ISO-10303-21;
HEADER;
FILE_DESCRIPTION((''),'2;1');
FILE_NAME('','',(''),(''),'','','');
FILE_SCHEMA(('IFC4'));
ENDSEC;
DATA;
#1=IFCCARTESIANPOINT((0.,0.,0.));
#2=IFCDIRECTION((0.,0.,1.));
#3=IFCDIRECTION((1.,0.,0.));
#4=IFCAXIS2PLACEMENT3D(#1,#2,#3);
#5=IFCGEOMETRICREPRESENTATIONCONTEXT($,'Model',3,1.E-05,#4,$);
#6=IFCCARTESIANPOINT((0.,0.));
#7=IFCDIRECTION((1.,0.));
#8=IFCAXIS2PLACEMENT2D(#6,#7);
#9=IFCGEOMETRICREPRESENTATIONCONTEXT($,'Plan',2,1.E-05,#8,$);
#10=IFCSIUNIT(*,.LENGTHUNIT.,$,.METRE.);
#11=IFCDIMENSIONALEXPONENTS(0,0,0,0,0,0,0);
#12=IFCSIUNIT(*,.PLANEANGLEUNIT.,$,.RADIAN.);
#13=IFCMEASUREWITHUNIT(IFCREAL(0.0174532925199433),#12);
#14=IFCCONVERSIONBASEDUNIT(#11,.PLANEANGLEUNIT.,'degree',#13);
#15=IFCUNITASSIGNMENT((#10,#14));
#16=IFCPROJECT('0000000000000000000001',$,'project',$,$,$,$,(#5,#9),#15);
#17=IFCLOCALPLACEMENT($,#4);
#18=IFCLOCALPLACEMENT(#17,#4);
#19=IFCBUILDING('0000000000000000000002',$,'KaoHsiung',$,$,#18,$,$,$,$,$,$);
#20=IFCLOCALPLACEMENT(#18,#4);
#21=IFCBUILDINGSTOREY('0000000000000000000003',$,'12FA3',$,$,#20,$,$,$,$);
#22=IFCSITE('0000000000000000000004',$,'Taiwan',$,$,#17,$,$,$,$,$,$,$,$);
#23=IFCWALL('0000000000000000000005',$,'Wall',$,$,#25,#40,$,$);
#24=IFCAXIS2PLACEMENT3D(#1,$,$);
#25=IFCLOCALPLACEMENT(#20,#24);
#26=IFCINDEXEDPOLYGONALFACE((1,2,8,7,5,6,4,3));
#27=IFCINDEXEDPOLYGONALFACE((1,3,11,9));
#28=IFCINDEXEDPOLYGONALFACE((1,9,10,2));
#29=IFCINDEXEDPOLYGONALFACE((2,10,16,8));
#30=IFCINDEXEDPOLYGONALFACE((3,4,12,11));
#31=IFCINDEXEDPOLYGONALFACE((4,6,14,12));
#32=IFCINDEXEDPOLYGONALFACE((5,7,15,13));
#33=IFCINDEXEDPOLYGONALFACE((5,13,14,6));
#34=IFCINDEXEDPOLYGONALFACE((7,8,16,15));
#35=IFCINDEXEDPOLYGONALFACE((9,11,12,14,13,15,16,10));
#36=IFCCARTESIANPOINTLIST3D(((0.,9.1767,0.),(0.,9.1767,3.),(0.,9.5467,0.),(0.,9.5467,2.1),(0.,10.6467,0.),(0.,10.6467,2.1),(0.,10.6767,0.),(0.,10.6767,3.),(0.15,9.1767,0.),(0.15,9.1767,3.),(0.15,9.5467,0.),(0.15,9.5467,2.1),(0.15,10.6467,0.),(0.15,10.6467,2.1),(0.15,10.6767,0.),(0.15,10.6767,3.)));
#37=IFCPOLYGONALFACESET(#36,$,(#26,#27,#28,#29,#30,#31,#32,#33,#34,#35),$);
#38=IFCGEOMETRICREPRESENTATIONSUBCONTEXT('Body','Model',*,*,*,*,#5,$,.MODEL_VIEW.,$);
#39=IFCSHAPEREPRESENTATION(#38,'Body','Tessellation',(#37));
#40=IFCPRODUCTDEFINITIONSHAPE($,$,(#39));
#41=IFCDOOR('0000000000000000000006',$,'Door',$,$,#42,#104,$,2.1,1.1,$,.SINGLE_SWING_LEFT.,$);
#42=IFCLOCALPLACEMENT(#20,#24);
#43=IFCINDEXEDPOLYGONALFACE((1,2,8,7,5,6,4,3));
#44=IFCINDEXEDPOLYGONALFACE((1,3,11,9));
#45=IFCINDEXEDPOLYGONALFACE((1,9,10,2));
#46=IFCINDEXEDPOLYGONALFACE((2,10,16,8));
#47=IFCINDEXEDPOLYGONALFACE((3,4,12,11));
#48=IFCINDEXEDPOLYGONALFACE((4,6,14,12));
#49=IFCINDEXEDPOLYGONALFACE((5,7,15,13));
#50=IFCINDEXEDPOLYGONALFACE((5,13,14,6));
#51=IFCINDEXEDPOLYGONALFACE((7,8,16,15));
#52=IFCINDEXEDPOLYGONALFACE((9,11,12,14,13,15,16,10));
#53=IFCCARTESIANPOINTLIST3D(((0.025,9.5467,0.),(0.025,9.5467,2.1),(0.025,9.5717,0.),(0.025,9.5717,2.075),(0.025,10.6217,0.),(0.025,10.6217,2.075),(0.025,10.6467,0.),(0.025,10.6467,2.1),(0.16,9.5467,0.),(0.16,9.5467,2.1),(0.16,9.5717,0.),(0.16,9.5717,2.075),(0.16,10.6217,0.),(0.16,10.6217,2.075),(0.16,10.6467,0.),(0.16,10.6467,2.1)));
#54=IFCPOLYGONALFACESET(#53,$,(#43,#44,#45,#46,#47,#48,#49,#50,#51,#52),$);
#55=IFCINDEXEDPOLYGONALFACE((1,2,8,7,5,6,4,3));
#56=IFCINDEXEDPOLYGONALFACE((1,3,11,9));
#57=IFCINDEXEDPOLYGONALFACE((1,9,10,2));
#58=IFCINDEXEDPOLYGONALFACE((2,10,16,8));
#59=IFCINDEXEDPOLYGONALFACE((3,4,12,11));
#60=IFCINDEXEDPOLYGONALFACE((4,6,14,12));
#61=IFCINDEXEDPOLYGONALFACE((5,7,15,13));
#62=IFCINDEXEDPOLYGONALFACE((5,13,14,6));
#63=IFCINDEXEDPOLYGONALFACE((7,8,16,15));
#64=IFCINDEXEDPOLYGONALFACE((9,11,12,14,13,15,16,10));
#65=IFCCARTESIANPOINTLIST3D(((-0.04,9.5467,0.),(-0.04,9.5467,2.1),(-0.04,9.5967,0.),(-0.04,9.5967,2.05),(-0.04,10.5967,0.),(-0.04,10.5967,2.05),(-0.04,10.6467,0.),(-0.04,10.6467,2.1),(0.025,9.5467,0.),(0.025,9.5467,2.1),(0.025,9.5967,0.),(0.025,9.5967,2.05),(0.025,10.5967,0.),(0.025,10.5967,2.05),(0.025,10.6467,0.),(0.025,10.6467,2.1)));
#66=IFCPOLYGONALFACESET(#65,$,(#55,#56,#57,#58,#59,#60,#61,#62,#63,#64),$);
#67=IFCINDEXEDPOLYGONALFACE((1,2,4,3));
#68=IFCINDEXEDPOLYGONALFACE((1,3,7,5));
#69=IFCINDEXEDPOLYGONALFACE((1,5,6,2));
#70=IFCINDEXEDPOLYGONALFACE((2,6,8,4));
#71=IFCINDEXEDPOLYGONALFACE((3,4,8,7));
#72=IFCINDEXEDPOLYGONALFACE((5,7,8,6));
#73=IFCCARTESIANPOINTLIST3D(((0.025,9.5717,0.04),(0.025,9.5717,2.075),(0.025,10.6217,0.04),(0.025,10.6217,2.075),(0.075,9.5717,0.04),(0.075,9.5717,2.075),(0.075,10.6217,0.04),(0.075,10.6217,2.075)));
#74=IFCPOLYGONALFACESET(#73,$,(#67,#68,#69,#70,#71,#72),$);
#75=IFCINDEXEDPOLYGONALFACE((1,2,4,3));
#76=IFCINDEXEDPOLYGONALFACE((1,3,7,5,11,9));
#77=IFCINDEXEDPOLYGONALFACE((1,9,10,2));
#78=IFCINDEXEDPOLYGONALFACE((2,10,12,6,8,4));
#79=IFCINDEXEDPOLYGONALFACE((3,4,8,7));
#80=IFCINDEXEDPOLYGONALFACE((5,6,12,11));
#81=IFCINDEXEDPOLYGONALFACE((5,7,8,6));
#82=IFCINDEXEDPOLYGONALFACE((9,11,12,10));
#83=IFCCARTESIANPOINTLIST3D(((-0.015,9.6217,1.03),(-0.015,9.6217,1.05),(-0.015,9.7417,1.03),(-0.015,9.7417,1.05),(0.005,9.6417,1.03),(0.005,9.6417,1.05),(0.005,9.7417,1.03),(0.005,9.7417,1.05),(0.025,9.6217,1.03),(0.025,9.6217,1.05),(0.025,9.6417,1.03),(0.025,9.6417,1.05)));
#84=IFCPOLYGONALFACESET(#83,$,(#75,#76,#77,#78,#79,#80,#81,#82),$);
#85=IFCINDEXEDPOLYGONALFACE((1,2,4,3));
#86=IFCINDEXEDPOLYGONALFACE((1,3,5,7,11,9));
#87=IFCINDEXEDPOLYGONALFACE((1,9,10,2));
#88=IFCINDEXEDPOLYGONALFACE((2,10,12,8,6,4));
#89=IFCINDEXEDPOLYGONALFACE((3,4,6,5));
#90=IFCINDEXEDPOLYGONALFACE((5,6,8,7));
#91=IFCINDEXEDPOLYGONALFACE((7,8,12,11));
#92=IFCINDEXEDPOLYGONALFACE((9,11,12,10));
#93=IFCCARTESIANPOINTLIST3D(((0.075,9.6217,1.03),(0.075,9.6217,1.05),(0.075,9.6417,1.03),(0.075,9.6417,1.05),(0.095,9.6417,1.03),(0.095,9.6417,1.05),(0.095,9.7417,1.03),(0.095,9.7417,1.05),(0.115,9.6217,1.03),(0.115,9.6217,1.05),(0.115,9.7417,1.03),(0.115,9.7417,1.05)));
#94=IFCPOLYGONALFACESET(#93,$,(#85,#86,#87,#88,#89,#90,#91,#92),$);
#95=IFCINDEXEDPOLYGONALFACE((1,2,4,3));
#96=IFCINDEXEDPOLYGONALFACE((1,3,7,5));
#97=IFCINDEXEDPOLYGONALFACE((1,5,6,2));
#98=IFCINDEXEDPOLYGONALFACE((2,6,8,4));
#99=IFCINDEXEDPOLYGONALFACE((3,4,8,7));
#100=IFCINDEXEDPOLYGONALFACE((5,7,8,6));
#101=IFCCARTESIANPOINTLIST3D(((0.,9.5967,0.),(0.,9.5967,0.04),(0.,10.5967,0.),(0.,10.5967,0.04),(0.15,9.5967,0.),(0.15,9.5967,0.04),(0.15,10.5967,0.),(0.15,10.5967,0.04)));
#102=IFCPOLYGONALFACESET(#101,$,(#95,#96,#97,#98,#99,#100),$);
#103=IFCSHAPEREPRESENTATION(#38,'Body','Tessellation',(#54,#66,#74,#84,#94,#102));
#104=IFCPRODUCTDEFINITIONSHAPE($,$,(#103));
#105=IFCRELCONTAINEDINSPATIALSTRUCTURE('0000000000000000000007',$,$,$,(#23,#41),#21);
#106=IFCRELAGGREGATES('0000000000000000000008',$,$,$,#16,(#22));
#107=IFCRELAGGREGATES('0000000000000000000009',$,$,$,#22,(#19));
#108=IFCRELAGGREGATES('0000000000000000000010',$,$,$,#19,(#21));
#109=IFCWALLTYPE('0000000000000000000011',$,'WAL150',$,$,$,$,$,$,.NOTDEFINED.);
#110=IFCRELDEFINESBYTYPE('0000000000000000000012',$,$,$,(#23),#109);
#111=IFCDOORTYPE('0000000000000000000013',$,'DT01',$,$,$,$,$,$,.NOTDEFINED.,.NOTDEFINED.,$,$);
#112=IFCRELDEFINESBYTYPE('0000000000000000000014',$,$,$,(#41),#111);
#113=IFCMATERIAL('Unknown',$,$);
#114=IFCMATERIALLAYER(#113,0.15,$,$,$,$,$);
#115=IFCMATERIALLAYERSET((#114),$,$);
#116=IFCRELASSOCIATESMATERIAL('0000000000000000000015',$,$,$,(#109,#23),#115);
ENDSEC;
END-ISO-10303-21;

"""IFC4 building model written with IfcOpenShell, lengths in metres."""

from ifc_helpers import new_model, entity, si_unit, converted_unit, frame, origin_with_axes, origin_2d_with_axis, place, context, subcontext, project, spatial, line, indexed_curve, outline, extrude, shape, source, transform, mapped, material, layer, layer_set, layer_usage, type_object, type_shapes, element, fill, save


model = new_model("IFC4")

# Units and contexts
model_context = context("Model", 3, precision=1e-05, world=origin_with_axes())
plan_context = context("Plan", 2, precision=1e-05, world=origin_2d_with_axis())
body_context_1 = subcontext(model_context, "Body", "Model", "MODEL_VIEW")
body_context_2 = subcontext(plan_context, "Body", "Plan", "PLAN_VIEW")
ifc_project = project(units=[si_unit("LENGTHUNIT", "METRE"), converted_unit("PLANEANGLEUNIT", "degree", entity("IfcReal", 0.0174532925199433), si_unit("PLANEANGLEUNIT", "RADIAN"), dimensions=[0, 0, 0, 0, 0, 0, 0])], contexts=[model_context, plan_context])

# Site, building, storey
site_placement = place(None, origin_with_axes())
site = spatial("IfcSite", under=ifc_project, at=site_placement, Name="Taiwan")
building_placement = place(site_placement, origin_with_axes())
building = spatial("IfcBuilding", under=site, at=building_placement, Name="KaoHsiung")
storey_placement = place(building_placement, origin_with_axes())
storey = spatial("IfcBuildingStorey", under=building, at=storey_placement, Name="12FA3")

# Shared definitions
ifc_material = material(Name="Unknown")

# Shared definitions
ifc_layer_1 = layer(ifc_material, 0.15)
ifc_layer_set_1 = layer_set([ifc_layer_1])
wall_type_1 = type_object("IfcWallType", Name="WAL150", PredefinedType="NOTDEFINED", material=ifc_layer_set_1)

# Wall, opening, door
ifc_layer_usage_1 = layer_usage(ifc_layer_set_1, "AXIS2", "POSITIVE", 0.0)
wall_1_placement = place(storey_placement, frame((0.0, 10.6767, 0.0), z_axis=(0.0, 0.0, 1.0), x_axis=(0.0, -1.0, 0.0)))
wall_1 = element("IfcWall", 1, at=wall_1_placement, inside=storey, type_object=wall_type_1, material=ifc_layer_usage_1, Name="Wall", context=body_context_1, shape_type="SweptSolid", body=[
    extrude(outline(indexed_curve([(0.0, 0.0), (0.0, 0.15), (1.5, 0.15), (1.5, 0.0)], segments=[line(1, 2, 3, 4, 1)])), origin_with_axes(), (0.0, 0.0, 1.0), 3.0),
])
shared_shape_1 = source(origin_with_axes(), body_context_1, "Body", "SweptSolid", [
    extrude(outline(indexed_curve([(0.0, 0.0), (1.1, 0.0), (1.1, 2.1), (0.0, 2.1)], segments=[line(1, 2, 3, 4, 1)])), frame((0.0, -0.6, 0.0), z_axis=(0.0, -1.0, 0.0), x_axis=(1.0, 0.0, 0.0)), (0.0, 0.0, -1.0), 1.2),
])
opening_1_placement = place(wall_1_placement, frame((0.03, 0.0, 0.0), z_axis=(0.0, 0.0, 1.0), x_axis=(1.0, 0.0, 0.0)))
opening_1 = element("IfcOpeningElement", 2, at=opening_1_placement, cuts=wall_1, PredefinedType="OPENING", context=body_context_1, shape_type="MappedRepresentation", body=[
    mapped(shared_shape_1, transform((0.0, 0.0, 0.0), x_axis=(1.0, 0.0, 0.0), y_axis=(0.0, 1.0, 0.0), z_axis=(0.0, 0.0, 1.0), scale=1.0)),
])
door_type_1 = type_object("IfcDoorType", Name="DT01", OperationType="NOTDEFINED", PredefinedType="NOTDEFINED")
shared_shape_2 = source(origin_with_axes(), body_context_1, "Body", "SweptSolid", [
    extrude(outline(indexed_curve([(0.0, 0.0), (0.0, 2.1), (1.1, 2.1), (1.1, 0.0), (1.075, 0.0), (1.075, 2.075), (0.025, 2.075), (0.025, 0.0)], segments=[line(1, 2, 3, 4, 5, 6, 7, 8, 1)])), frame((0.0, 0.025, 0.0), z_axis=(0.0, -1.0, 0.0), x_axis=(1.0, 0.0, 0.0)), (0.0, 0.0, -1.0), 0.135),
    extrude(outline(indexed_curve([(0.0, 0.0), (0.0, 2.1), (1.1, 2.1), (1.1, 0.0), (1.05, 0.0), (1.05, 2.05), (0.05, 2.05), (0.05, 0.0)], segments=[line(1, 2, 3, 4, 5, 6, 7, 8, 1)])), frame((0.0, -0.04, 0.0), z_axis=(0.0, -1.0, 0.0), x_axis=(1.0, 0.0, 0.0)), (0.0, 0.0, -1.0), 0.065),
    extrude(outline(indexed_curve([(0.0, 0.0), (1.05, 0.0), (1.05, 0.05), (0.0, 0.05)], segments=[line(1, 2, 3, 4, 1)])), frame((0.025, 0.025, 0.04), z_axis=(0.0, 0.0, 1.0), x_axis=(1.0, 0.0, 0.0)), (0.0, 0.0, 1.0), 2.035),
    extrude(outline(indexed_curve([(0.0, 0.0), (0.0, -0.04), (-0.12, -0.04), (-0.12, -0.02), (-0.02, -0.02), (-0.02, 0.0)], segments=[line(1, 2, 3, 4, 5, 6, 1)])), frame((1.025, 0.025, 1.03), z_axis=(0.0, 0.0, 1.0), x_axis=(1.0, 0.0, 0.0)), (0.0, 0.0, 1.0), 0.02),
    extrude(outline(indexed_curve([(0.0, 0.0), (0.0, 0.04), (-0.12, 0.04), (-0.12, 0.02), (-0.02, 0.02), (-0.02, 0.0)], segments=[line(1, 2, 3, 4, 5, 6, 1)])), frame((1.025, 0.075, 1.03), z_axis=(0.0, 0.0, 1.0), x_axis=(1.0, 0.0, 0.0)), (0.0, 0.0, 1.0), 0.02),
    extrude(outline(indexed_curve([(0.0, 0.0), (1.0, 0.0), (1.0, 0.15), (0.0, 0.15)], segments=[line(1, 2, 3, 4, 1)])), frame((0.05, 0.0, 0.0), z_axis=(0.0, 0.0, 1.0), x_axis=(1.0, 0.0, 0.0)), (0.0, 0.0, 1.0), 0.04),
])
shared_shape_3 = source(origin_with_axes(), body_context_2, "Body", "Curve2D", [
    entity("IfcIndexedPolyCurve", entity("IfcCartesianPointList2D", [[0.0, -0.04], [0.0, 0.16], [0.025, 0.16], [0.025, 0.025], [0.05, 0.025], [0.05, -0.04]]), [entity("IfcLineIndex", [1, 2, 3, 4, 5, 6, 1])]),
    entity("IfcIndexedPolyCurve", entity("IfcCartesianPointList2D", [[1.1, -0.04], [1.1, 0.16], [1.075, 0.16], [1.075, 0.025], [1.05, 0.025], [1.05, -0.04]]), [entity("IfcLineIndex", [1, 2, 3, 4, 5, 6, 1])]),
    entity("IfcTrimmedCurve", entity("IfcEllipse", entity("IfcAxis2Placement2D", entity("IfcCartesianPoint", [0.075, 0.16]), entity("IfcDirection", [1.0, 0.0])), 1.0, 1.05), [entity("IfcCartesianPoint", [1.075, 0.16])], [entity("IfcCartesianPoint", [0.075, 1.21])], True, "CARTESIAN"),
    entity("IfcIndexedPolyCurve", entity("IfcCartesianPointList2D", [[0.025, 0.16], [0.075, 0.16], [0.075, 1.21], [0.025, 1.21]]), [entity("IfcLineIndex", [1, 2, 3, 4, 1])]),
])
type_shapes(door_type_1, [shared_shape_2, shared_shape_3])
door_1_placement = place(opening_1_placement, frame((0.0, 0.0, 0.0), z_axis=(0.0, 0.0, 1.0), x_axis=(1.0, 0.0, 0.0)))
door_1 = element("IfcDoor", 3, at=door_1_placement, inside=storey, type_object=door_type_1, Name="Door", OperationType="SINGLE_SWING_LEFT", OverallHeight=2.1, OverallWidth=1.1, shapes=[
    shape(body_context_1, "Body", "MappedRepresentation", [mapped(shared_shape_2, transform((0.0, 0.0, 0.0), x_axis=(1.0, 0.0, 0.0), y_axis=(0.0, 1.0, 0.0), z_axis=(0.0, 0.0, 1.0), scale=1.0))]),
    shape(body_context_2, "Body", "MappedRepresentation", [mapped(shared_shape_3, transform((0.0, 0.0, 0.0), x_axis=(1.0, 0.0, 0.0), y_axis=(0.0, 1.0, 0.0), z_axis=(0.0, 0.0, 1.0), scale=1.0))]),
])
fill(opening_1, door_1)

save(model, "model.ifc")
